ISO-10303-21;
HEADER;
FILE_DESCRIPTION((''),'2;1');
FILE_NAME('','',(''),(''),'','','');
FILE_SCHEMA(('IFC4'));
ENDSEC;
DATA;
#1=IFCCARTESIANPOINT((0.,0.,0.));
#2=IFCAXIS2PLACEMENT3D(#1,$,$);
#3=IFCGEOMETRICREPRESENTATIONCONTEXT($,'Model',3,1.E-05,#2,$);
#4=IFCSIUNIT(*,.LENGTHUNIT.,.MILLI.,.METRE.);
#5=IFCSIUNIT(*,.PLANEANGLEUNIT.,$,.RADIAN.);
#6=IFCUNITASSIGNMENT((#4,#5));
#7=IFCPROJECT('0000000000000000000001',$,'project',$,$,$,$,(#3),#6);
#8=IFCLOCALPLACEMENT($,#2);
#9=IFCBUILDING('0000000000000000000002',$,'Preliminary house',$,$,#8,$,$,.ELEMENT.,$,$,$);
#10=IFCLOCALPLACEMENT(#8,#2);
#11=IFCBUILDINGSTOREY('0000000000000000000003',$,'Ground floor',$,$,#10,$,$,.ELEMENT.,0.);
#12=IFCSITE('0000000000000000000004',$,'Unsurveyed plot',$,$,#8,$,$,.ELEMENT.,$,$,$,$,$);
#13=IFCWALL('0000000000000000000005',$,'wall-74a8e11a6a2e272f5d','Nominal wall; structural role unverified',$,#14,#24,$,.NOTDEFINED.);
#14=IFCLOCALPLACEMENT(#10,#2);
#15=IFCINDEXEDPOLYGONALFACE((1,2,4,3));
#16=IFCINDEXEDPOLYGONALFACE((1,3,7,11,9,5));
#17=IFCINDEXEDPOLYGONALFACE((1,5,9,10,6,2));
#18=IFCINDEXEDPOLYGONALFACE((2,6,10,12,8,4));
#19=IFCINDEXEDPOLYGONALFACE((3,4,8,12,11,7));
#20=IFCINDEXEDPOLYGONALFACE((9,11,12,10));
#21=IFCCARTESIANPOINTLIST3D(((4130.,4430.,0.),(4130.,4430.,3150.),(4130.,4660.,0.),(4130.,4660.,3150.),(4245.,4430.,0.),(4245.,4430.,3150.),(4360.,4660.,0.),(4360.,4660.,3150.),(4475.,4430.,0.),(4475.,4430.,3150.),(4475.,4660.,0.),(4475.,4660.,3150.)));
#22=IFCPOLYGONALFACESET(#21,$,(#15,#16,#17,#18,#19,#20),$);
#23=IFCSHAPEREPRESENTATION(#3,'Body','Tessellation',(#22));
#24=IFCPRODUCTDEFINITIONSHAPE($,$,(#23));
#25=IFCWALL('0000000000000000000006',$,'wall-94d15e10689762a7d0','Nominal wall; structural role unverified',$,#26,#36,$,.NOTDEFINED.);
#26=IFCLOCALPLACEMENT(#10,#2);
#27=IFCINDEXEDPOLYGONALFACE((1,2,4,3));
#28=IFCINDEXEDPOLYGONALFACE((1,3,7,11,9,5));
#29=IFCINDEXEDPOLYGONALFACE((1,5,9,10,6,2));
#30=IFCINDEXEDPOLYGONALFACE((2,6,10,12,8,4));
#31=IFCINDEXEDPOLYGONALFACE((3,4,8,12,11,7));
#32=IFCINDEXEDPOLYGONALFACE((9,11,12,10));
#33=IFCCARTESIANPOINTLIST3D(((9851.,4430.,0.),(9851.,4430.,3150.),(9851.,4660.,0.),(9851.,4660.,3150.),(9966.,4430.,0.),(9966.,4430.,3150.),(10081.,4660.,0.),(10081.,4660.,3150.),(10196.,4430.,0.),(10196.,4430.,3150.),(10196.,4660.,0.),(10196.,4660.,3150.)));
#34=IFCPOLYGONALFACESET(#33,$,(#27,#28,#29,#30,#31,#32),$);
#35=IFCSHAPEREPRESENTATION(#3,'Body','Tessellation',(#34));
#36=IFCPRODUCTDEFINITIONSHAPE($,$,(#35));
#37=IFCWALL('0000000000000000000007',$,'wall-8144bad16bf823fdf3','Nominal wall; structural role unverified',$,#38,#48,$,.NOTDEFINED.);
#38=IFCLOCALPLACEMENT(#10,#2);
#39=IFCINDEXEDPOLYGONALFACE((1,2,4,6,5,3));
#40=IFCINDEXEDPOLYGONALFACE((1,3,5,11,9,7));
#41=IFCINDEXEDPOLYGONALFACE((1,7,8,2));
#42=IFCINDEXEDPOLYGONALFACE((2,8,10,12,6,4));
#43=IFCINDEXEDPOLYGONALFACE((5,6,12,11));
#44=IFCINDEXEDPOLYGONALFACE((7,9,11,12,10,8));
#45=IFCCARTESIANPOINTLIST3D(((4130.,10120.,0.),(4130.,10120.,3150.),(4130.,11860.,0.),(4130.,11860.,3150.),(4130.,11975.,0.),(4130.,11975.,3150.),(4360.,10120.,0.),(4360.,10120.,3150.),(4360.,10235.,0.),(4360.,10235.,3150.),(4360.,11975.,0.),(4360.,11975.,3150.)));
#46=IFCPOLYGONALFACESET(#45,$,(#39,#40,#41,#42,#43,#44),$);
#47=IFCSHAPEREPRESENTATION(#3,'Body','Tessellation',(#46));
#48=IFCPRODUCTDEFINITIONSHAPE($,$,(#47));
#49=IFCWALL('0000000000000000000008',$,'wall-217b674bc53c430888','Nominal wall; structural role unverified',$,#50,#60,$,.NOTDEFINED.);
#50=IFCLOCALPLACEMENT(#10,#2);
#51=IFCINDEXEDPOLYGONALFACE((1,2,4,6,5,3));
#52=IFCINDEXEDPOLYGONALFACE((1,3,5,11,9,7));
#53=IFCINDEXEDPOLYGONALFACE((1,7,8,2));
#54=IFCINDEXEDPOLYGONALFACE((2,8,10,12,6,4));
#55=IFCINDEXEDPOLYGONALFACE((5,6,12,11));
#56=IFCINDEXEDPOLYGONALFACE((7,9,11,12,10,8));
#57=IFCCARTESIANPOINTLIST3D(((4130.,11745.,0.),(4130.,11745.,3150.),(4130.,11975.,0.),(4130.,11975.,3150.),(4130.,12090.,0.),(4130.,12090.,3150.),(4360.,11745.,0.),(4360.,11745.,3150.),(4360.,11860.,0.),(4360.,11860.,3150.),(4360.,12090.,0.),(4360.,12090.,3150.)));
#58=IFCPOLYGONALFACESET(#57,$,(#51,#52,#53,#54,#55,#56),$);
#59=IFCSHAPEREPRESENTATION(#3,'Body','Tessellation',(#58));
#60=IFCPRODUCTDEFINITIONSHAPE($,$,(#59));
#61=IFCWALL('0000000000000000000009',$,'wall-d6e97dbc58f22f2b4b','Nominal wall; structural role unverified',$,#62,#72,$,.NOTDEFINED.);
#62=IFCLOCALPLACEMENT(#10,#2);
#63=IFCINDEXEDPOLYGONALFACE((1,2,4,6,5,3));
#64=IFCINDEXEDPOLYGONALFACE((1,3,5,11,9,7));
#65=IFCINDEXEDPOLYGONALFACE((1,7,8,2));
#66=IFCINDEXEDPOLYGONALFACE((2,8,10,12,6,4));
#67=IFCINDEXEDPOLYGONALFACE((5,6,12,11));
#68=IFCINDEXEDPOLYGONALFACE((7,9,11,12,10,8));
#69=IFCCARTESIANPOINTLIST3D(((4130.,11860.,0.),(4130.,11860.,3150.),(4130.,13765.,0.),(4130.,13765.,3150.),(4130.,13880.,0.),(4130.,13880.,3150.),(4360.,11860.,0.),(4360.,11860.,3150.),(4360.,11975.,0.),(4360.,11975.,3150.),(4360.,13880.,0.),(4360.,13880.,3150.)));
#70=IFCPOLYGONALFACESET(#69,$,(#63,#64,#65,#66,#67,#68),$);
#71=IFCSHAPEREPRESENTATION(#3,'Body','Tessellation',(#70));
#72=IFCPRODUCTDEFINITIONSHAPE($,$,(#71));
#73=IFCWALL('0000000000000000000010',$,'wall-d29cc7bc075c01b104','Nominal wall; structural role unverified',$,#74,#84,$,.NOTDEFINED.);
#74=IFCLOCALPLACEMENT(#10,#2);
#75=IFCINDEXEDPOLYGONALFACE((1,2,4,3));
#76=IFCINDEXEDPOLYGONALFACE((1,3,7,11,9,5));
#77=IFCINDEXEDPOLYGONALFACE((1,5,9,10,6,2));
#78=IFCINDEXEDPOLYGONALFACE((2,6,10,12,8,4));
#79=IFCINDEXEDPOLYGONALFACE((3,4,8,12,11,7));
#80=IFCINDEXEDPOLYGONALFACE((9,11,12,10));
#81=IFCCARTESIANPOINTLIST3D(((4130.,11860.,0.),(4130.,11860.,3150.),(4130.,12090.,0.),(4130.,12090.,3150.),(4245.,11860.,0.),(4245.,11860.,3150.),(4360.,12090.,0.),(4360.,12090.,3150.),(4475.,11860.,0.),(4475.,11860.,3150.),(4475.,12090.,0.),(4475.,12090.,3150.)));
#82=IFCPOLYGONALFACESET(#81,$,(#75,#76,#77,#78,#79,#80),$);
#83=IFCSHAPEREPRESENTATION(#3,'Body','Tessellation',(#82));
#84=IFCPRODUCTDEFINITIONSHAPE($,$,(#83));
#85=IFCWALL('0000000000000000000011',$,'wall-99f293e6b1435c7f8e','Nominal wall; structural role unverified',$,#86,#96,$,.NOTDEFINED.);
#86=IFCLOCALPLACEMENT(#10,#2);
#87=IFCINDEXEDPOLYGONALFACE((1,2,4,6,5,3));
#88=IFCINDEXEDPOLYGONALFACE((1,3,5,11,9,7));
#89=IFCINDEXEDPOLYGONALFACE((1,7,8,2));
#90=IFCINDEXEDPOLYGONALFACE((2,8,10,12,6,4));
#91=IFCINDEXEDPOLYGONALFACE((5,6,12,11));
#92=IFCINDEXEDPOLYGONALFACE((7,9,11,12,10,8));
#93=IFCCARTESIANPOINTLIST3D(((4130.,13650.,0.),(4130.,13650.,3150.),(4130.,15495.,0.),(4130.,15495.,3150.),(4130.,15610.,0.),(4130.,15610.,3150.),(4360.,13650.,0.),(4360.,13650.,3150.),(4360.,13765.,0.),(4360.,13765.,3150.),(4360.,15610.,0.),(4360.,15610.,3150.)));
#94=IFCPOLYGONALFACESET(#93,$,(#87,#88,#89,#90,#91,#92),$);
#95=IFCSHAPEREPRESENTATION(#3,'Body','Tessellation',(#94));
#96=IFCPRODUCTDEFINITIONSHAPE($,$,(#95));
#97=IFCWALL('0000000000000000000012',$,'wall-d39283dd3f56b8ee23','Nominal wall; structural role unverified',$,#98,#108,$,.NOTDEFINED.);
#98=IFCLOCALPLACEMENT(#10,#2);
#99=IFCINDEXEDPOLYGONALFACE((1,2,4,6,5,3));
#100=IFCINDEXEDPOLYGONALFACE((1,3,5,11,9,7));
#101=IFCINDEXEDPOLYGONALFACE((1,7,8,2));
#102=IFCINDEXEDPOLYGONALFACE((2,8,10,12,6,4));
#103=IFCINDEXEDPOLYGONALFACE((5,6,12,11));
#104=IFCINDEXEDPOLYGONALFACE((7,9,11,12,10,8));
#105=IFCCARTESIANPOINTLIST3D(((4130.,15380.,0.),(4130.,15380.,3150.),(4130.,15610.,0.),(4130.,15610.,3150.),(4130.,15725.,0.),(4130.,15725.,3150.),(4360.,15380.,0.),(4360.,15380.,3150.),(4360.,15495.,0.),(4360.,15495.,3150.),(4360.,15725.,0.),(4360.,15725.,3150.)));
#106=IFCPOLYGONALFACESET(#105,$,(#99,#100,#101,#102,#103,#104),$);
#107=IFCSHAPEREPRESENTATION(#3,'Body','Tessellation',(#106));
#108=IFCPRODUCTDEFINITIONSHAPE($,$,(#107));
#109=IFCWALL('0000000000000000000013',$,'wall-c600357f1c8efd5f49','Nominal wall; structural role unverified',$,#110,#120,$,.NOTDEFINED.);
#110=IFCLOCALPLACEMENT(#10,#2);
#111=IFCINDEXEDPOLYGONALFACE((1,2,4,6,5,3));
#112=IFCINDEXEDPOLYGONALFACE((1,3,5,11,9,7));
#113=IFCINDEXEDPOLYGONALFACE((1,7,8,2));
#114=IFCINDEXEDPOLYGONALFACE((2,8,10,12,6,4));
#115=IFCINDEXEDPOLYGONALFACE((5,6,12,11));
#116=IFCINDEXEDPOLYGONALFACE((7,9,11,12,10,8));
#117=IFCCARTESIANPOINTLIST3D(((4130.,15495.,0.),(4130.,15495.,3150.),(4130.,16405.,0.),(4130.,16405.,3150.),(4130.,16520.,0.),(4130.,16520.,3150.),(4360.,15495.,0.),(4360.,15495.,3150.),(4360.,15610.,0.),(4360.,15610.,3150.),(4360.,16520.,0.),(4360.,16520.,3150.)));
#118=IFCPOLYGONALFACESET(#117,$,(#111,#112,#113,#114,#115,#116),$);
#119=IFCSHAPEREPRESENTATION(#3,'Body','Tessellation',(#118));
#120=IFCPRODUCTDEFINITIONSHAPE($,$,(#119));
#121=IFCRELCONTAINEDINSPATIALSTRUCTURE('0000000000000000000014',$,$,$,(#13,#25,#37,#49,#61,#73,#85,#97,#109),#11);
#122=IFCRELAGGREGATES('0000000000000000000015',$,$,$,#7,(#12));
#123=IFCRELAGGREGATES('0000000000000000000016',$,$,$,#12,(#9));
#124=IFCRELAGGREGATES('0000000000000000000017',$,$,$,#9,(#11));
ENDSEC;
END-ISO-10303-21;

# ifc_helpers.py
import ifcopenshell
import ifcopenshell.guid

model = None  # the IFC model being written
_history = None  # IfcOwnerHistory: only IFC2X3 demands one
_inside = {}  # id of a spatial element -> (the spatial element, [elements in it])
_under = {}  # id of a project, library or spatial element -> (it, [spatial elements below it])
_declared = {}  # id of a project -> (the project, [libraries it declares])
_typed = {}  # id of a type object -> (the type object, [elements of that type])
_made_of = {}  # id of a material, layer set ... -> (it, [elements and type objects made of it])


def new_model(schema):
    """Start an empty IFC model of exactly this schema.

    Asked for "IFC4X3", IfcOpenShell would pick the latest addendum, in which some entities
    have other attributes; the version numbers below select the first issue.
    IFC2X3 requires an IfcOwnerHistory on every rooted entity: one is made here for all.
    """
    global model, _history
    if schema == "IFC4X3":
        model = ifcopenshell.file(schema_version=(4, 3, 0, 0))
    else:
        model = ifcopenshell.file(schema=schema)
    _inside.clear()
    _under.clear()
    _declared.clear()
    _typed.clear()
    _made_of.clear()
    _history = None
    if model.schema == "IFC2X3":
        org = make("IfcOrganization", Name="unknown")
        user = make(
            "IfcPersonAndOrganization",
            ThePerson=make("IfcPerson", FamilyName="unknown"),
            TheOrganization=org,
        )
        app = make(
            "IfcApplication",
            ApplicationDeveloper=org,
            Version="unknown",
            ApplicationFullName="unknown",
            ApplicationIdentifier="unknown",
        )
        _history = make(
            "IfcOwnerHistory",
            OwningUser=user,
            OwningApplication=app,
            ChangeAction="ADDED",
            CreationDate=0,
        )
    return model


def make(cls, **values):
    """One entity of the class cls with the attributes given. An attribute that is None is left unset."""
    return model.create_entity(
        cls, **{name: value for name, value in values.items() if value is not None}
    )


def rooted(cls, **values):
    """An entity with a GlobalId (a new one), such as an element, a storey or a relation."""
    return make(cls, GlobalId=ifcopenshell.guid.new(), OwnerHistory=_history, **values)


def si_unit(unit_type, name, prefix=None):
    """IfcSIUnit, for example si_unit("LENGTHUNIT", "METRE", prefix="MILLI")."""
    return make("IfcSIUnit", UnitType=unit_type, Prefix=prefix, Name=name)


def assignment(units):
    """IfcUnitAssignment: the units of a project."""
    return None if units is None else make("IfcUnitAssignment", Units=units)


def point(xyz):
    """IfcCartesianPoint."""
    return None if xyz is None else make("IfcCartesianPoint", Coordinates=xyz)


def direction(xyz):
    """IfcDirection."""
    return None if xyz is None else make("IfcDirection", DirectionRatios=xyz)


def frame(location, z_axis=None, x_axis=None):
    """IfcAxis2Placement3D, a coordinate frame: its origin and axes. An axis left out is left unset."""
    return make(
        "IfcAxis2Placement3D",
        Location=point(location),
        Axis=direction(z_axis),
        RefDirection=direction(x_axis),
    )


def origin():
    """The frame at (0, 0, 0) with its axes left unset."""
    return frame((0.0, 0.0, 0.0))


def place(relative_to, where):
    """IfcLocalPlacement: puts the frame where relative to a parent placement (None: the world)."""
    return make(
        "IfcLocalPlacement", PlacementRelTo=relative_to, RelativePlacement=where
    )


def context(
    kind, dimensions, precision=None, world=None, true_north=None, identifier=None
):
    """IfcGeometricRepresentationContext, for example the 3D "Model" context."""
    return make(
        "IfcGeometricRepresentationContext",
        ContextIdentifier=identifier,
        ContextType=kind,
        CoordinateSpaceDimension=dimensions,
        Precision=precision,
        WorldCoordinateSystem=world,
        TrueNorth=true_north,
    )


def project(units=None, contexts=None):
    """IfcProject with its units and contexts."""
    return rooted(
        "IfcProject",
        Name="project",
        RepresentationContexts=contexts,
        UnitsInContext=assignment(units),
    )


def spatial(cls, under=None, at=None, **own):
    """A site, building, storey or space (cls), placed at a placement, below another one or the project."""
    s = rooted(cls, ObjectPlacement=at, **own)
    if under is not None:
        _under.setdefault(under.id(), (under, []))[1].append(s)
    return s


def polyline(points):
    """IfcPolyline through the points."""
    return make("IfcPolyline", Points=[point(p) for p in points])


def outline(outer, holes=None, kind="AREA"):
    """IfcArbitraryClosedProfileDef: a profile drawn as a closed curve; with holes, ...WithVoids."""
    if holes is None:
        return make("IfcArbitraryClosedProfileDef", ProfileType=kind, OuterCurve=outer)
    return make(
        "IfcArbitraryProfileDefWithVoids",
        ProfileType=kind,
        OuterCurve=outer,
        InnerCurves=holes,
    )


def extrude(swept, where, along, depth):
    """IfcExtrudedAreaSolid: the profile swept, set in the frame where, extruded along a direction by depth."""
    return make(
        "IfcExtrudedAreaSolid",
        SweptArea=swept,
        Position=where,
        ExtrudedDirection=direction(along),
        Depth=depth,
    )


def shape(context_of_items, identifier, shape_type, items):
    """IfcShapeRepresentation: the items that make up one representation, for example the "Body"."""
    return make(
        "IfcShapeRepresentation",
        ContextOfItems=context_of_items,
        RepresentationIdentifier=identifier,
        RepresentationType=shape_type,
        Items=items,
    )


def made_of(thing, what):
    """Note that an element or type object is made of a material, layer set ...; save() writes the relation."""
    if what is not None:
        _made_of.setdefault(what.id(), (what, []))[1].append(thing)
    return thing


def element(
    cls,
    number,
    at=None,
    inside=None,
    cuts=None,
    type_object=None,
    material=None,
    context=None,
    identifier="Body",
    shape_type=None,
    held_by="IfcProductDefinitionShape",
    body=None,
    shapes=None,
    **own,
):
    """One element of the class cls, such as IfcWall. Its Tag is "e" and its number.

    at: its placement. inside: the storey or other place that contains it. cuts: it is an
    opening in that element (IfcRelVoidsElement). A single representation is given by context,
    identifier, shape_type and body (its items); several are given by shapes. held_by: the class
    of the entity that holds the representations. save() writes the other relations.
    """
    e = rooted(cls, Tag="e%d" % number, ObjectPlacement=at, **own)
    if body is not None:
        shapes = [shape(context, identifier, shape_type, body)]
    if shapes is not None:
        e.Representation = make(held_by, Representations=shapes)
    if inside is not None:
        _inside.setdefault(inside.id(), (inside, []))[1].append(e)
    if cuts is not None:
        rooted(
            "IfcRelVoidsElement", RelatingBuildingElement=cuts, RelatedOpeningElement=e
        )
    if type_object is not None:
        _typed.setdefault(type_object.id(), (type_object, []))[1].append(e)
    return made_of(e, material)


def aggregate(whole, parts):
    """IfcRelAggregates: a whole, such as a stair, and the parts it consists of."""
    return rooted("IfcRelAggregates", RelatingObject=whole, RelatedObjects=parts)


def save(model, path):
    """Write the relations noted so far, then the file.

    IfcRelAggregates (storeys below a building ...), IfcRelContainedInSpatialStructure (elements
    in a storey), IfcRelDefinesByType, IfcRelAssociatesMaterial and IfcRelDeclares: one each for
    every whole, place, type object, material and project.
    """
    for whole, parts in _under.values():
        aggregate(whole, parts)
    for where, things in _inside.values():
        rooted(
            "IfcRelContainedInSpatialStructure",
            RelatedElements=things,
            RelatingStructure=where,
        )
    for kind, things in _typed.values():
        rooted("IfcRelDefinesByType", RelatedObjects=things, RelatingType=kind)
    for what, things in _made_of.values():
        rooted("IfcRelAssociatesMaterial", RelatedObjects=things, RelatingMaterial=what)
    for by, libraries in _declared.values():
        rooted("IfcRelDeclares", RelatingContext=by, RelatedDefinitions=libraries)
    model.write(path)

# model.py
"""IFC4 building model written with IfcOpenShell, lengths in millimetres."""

from ifc_helpers import new_model, si_unit, origin, place, context, project, spatial, polyline, outline, extrude, element, save


model = new_model("IFC4")

# Units and contexts
model_context = context("Model", 3, precision=1e-05, world=origin())
ifc_project = project(units=[si_unit("LENGTHUNIT", "METRE", prefix="MILLI"), si_unit("PLANEANGLEUNIT", "RADIAN")], contexts=[model_context])

# Site, building, storey
placement_1 = place(None, origin())
site = spatial("IfcSite", under=ifc_project, at=placement_1, Name="Unsurveyed plot", CompositionType="ELEMENT")
building = spatial("IfcBuilding", under=site, at=placement_1, Name="Preliminary house", CompositionType="ELEMENT")
placement_2 = place(placement_1, origin())
storey = spatial("IfcBuildingStorey", under=building, at=placement_2, Name="Ground floor", CompositionType="ELEMENT", Elevation=0.0)

# Wall
element("IfcWall", 1, at=placement_2, inside=storey, Name="wall-74a8e11a6a2e272f5d", Description="Nominal wall; structural role unverified", PredefinedType="NOTDEFINED", context=model_context, shape_type="SweptSolid", body=[
    extrude(outline(polyline([(4360.0, 4660.0), (4475.0, 4660.0), (4475.0, 4430.0), (4245.0, 4430.0), (4130.0, 4430.0), (4130.0, 4660.0), (4360.0, 4660.0)])), origin(), (0.0, 0.0, 1.0), 3150.0),
])

# Wall
element("IfcWall", 2, at=placement_2, inside=storey, Name="wall-94d15e10689762a7d0", Description="Nominal wall; structural role unverified", PredefinedType="NOTDEFINED", context=model_context, shape_type="SweptSolid", body=[
    extrude(outline(polyline([(10081.0, 4660.0), (10196.0, 4660.0), (10196.0, 4430.0), (9966.0, 4430.0), (9851.0, 4430.0), (9851.0, 4660.0), (10081.0, 4660.0)])), origin(), (0.0, 0.0, 1.0), 3150.0),
])

# Walls
element("IfcWall", 3, at=placement_2, inside=storey, Name="wall-8144bad16bf823fdf3", Description="Nominal wall; structural role unverified", PredefinedType="NOTDEFINED", context=model_context, shape_type="SweptSolid", body=[
    extrude(outline(polyline([(4130.0, 11860.0), (4130.0, 11975.0), (4360.0, 11975.0), (4360.0, 10235.0), (4360.0, 10120.0), (4130.0, 10120.0), (4130.0, 11860.0)])), origin(), (0.0, 0.0, 1.0), 3150.0),
])
element("IfcWall", 4, at=placement_2, inside=storey, Name="wall-217b674bc53c430888", Description="Nominal wall; structural role unverified", PredefinedType="NOTDEFINED", context=model_context, shape_type="SweptSolid", body=[
    extrude(outline(polyline([(4130.0, 11975.0), (4130.0, 12090.0), (4360.0, 12090.0), (4360.0, 11860.0), (4360.0, 11745.0), (4130.0, 11745.0), (4130.0, 11975.0)])), origin(), (0.0, 0.0, 1.0), 3150.0),
])
element("IfcWall", 5, at=placement_2, inside=storey, Name="wall-d6e97dbc58f22f2b4b", Description="Nominal wall; structural role unverified", PredefinedType="NOTDEFINED", context=model_context, shape_type="SweptSolid", body=[
    extrude(outline(polyline([(4130.0, 13765.0), (4130.0, 13880.0), (4360.0, 13880.0), (4360.0, 11975.0), (4360.0, 11860.0), (4130.0, 11860.0), (4130.0, 13765.0)])), origin(), (0.0, 0.0, 1.0), 3150.0),
])
element("IfcWall", 6, at=placement_2, inside=storey, Name="wall-d29cc7bc075c01b104", Description="Nominal wall; structural role unverified", PredefinedType="NOTDEFINED", context=model_context, shape_type="SweptSolid", body=[
    extrude(outline(polyline([(4360.0, 12090.0), (4475.0, 12090.0), (4475.0, 11860.0), (4245.0, 11860.0), (4130.0, 11860.0), (4130.0, 12090.0), (4360.0, 12090.0)])), origin(), (0.0, 0.0, 1.0), 3150.0),
])

# Walls
element("IfcWall", 7, at=placement_2, inside=storey, Name="wall-99f293e6b1435c7f8e", Description="Nominal wall; structural role unverified", PredefinedType="NOTDEFINED", context=model_context, shape_type="SweptSolid", body=[
    extrude(outline(polyline([(4130.0, 15495.0), (4130.0, 15610.0), (4360.0, 15610.0), (4360.0, 13765.0), (4360.0, 13650.0), (4130.0, 13650.0), (4130.0, 15495.0)])), origin(), (0.0, 0.0, 1.0), 3150.0),
])
element("IfcWall", 8, at=placement_2, inside=storey, Name="wall-d39283dd3f56b8ee23", Description="Nominal wall; structural role unverified", PredefinedType="NOTDEFINED", context=model_context, shape_type="SweptSolid", body=[
    extrude(outline(polyline([(4130.0, 15610.0), (4130.0, 15725.0), (4360.0, 15725.0), (4360.0, 15495.0), (4360.0, 15380.0), (4130.0, 15380.0), (4130.0, 15610.0)])), origin(), (0.0, 0.0, 1.0), 3150.0),
])
element("IfcWall", 9, at=placement_2, inside=storey, Name="wall-c600357f1c8efd5f49", Description="Nominal wall; structural role unverified", PredefinedType="NOTDEFINED", context=model_context, shape_type="SweptSolid", body=[
    extrude(outline(polyline([(4130.0, 16405.0), (4130.0, 16520.0), (4360.0, 16520.0), (4360.0, 15610.0), (4360.0, 15495.0), (4130.0, 15495.0), (4130.0, 16405.0)])), origin(), (0.0, 0.0, 1.0), 3150.0),
])

save(model, "model.ifc")
